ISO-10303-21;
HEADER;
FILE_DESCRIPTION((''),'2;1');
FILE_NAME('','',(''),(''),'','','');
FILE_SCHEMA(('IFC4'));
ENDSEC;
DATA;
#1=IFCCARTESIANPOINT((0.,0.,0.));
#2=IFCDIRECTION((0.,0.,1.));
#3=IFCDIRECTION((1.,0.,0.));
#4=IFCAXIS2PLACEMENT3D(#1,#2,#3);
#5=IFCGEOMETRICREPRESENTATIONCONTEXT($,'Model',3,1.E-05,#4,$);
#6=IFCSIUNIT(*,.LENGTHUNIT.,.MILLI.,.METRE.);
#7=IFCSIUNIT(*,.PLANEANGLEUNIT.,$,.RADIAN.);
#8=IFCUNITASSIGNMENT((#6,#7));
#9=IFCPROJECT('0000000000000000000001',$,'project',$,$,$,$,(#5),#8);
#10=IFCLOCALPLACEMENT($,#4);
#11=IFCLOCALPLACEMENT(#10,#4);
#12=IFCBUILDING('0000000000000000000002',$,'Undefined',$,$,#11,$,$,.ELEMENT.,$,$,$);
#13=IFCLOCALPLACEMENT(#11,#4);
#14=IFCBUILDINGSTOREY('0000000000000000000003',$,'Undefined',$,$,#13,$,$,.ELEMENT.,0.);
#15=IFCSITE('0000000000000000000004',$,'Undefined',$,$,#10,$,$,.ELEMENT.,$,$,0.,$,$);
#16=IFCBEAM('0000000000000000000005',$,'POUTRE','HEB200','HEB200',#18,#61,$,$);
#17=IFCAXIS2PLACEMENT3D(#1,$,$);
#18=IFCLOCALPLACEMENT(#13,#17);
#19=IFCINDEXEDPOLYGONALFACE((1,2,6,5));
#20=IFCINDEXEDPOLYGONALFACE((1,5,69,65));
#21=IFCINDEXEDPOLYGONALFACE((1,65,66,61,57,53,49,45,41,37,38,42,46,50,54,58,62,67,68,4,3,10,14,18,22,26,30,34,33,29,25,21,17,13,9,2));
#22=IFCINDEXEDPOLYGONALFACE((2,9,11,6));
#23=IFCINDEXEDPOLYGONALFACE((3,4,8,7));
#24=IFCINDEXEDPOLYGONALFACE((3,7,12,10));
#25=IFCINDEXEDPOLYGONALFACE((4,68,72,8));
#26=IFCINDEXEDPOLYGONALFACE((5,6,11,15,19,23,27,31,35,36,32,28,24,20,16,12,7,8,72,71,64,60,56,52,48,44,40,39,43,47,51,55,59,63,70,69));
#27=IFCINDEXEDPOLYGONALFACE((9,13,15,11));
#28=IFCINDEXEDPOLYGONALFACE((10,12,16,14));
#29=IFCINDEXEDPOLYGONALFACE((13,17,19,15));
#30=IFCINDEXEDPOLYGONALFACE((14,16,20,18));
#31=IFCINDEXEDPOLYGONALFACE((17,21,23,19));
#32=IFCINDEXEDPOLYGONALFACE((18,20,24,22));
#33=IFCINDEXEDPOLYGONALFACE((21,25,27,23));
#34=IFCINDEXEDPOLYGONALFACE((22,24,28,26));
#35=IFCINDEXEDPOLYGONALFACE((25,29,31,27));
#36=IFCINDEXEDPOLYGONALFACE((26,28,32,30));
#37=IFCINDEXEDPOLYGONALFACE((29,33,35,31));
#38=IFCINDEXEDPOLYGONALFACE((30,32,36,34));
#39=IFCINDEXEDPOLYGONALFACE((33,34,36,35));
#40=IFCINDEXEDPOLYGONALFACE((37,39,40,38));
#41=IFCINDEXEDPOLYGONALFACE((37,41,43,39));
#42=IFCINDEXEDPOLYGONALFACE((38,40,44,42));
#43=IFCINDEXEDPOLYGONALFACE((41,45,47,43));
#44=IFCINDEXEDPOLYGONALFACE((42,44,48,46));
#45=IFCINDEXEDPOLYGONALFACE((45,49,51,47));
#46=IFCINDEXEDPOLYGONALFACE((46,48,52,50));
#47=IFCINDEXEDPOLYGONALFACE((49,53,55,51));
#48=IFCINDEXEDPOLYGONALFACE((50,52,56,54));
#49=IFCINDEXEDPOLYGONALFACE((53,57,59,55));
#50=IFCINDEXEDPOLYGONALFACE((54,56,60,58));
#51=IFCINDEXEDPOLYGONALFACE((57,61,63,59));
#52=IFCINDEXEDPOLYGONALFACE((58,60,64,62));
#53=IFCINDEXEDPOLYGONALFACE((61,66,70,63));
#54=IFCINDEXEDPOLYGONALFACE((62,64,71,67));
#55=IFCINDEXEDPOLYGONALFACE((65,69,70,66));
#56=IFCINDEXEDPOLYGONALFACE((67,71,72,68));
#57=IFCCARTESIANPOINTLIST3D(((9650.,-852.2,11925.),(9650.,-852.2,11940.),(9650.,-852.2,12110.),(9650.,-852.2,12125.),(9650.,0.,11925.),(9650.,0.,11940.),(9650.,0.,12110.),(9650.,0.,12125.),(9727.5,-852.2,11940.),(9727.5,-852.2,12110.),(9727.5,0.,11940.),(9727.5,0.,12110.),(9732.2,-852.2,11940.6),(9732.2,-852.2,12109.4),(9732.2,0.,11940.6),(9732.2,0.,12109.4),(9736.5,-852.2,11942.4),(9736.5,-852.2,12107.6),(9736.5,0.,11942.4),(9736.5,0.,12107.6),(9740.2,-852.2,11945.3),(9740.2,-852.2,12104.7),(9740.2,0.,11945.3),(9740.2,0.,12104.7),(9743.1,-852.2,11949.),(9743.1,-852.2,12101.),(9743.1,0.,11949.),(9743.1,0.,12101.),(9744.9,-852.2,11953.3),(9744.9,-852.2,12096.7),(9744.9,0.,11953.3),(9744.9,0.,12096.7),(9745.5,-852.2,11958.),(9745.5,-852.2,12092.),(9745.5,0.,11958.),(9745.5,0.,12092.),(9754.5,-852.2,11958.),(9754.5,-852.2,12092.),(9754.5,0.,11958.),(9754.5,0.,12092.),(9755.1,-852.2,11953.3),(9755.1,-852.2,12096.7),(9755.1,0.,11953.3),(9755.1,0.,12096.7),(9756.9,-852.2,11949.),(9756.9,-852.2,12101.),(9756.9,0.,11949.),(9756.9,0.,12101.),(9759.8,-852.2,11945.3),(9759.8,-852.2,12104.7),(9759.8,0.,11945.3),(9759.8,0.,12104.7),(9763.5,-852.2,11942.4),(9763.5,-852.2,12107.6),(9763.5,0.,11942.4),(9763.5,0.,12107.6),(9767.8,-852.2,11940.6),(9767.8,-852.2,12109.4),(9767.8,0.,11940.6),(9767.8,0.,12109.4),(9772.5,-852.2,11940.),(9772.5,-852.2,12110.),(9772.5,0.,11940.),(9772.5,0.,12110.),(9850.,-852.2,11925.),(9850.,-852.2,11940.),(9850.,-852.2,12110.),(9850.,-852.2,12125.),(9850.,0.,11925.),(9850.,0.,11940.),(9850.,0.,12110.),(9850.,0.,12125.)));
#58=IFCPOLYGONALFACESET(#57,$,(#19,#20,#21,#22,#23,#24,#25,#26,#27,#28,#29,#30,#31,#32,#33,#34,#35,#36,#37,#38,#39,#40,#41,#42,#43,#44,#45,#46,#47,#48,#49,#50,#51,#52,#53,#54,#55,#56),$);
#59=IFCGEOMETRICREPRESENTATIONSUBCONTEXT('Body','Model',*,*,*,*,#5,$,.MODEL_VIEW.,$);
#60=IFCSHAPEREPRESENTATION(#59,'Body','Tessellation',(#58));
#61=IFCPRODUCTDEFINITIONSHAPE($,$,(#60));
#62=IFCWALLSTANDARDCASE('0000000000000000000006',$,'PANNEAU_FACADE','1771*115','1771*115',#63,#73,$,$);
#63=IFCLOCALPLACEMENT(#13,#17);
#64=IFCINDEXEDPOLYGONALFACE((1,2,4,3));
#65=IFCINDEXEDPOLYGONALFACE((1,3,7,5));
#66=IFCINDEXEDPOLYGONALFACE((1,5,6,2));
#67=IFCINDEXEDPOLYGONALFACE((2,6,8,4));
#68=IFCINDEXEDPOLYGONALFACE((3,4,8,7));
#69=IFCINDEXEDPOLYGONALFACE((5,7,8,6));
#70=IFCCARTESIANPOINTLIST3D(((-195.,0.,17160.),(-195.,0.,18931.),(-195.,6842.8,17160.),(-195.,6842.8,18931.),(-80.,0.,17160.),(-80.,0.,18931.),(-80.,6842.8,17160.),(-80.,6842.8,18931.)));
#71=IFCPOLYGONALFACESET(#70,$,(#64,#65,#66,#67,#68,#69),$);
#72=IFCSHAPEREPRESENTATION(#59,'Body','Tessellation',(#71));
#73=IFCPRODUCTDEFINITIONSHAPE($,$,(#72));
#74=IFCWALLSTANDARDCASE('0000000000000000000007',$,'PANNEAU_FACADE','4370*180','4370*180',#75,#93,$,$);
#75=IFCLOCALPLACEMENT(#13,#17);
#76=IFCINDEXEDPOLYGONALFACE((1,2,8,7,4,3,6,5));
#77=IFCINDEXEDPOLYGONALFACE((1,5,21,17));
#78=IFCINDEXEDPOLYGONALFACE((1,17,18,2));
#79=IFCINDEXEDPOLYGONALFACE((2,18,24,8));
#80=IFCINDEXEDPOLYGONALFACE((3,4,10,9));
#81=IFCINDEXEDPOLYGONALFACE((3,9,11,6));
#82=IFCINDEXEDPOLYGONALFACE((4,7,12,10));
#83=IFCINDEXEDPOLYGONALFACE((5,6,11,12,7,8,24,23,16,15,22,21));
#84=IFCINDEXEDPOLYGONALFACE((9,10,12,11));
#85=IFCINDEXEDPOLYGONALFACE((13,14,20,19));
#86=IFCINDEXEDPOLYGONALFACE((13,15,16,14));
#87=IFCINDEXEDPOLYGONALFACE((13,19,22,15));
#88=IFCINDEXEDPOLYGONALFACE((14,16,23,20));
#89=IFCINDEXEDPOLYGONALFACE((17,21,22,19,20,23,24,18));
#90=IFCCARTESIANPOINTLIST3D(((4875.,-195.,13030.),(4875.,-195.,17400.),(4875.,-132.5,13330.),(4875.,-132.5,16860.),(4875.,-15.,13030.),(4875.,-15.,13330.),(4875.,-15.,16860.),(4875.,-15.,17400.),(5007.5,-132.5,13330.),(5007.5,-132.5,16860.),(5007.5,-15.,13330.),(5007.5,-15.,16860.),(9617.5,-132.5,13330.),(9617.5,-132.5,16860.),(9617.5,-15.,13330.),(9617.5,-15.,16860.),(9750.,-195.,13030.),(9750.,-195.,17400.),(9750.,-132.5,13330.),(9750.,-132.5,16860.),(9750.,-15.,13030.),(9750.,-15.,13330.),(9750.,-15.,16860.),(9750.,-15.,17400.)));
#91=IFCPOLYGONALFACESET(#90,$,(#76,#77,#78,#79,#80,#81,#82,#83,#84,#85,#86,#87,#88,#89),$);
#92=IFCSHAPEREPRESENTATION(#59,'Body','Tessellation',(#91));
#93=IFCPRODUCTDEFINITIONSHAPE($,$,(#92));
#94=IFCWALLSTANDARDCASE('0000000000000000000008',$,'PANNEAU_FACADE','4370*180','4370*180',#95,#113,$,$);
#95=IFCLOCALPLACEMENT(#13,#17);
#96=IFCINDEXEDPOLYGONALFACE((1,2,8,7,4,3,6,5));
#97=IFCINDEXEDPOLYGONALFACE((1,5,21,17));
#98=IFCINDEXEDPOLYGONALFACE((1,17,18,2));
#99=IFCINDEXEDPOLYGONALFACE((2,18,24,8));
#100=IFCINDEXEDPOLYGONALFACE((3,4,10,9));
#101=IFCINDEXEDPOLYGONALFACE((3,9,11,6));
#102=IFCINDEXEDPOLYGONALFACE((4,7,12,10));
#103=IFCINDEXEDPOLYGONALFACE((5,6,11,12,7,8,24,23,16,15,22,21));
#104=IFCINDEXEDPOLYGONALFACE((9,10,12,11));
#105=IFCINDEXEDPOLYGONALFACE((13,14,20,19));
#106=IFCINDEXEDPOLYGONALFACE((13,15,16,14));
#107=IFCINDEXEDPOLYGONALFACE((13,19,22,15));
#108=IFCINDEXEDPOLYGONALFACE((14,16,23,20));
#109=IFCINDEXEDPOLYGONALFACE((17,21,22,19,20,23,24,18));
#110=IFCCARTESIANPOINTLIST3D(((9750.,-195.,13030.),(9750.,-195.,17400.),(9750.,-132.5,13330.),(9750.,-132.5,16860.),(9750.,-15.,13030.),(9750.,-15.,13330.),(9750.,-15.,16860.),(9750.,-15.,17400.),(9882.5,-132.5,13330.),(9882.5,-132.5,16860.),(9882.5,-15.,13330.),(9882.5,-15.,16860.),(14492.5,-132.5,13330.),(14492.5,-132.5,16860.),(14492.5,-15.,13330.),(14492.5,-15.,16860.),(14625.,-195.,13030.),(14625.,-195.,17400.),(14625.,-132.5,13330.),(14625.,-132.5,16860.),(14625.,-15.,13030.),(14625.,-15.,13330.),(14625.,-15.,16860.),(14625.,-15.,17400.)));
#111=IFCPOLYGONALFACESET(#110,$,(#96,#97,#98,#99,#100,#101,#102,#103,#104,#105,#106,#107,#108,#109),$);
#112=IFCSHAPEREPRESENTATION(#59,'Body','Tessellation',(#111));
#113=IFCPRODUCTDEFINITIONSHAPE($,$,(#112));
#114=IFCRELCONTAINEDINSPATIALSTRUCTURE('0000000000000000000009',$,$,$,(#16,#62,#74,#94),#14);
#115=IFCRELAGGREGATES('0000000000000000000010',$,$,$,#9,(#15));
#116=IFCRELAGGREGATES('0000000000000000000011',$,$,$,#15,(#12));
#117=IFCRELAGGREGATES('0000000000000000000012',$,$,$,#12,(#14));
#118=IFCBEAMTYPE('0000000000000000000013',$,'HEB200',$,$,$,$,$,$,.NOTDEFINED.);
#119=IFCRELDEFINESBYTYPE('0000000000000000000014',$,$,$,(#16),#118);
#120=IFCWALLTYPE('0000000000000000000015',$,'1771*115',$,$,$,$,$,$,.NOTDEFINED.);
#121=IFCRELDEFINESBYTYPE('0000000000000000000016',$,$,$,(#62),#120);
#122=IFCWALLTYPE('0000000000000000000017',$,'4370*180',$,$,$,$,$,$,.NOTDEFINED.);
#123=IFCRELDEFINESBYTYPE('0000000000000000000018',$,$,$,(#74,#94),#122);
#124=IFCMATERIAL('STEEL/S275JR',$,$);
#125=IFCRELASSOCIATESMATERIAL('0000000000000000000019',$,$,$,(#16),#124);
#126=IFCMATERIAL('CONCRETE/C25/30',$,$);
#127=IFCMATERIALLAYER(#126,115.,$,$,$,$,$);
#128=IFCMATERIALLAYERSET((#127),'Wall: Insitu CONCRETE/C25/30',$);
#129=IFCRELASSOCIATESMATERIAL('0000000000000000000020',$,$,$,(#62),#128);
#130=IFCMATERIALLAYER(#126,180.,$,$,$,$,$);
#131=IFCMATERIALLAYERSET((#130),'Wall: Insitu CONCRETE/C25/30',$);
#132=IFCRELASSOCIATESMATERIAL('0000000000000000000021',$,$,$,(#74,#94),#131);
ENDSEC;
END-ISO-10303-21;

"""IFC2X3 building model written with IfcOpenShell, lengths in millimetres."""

from ifc_helpers import new_model, si_unit, frame, frame_2d, origin_with_axes, origin_2d_with_axis, place, context, subcontext, project, spatial, rectangle, i_section, extrude, boolean, material, layer, layer_set, layer_usage, type_object, element, save


model = new_model("IFC2X3")

# Units and contexts
model_context = context("Model", 3, precision=1e-05, world=origin_with_axes())
body_context = subcontext(model_context, "Body", "Model", "MODEL_VIEW")
ifc_project = project(units=[si_unit("LENGTHUNIT", "METRE", prefix="MILLI"), si_unit("PLANEANGLEUNIT", "RADIAN")], contexts=[model_context])

# Site, building, storey
site_placement = place(None, origin_with_axes())
site = spatial("IfcSite", under=ifc_project, at=site_placement, Name="Undefined", CompositionType="ELEMENT", RefElevation=0.0)
building_placement = place(site_placement, origin_with_axes())
building = spatial("IfcBuilding", under=site, at=building_placement, Name="Undefined", CompositionType="ELEMENT")
storey_placement = place(building_placement, origin_with_axes())
storey = spatial("IfcBuildingStorey", under=building, at=storey_placement, Name="Undefined", CompositionType="ELEMENT", Elevation=0.0)

# Shared definitions
ifc_material_1 = material(Name="CONCRETE/C25/30")
ifc_material_2 = material(Name="STEEL/S275JR")

# Beam
beam_type_1 = type_object("IfcBeamType", Name="HEB200", PredefinedType="NOTDEFINED")
beam_1_placement = place(storey_placement, frame((9750.0, 0.0, 12025.0), z_axis=(0.0, 0.0, 1.0), x_axis=(0.0, -1.0, 0.0)))
element("IfcBeam", 1, at=beam_1_placement, inside=storey, type_object=beam_type_1, material=ifc_material_2, Name="POUTRE", Description="HEB200", ObjectType="HEB200", context=body_context, shape_type="SweptSolid", body=[
    extrude(i_section(OverallWidth=200.0, OverallDepth=200.0, WebThickness=9.0, FlangeThickness=15.0, FilletRadius=18.0, at=origin_2d_with_axis()), frame((852.2, 0.0, 0.0), z_axis=(-1.0, 0.0, 0.0), x_axis=(0.0, -1.0, 0.0)), (0.0, 0.0, 1.0), 852.2),
])

# Walls
ifc_layer_1 = layer(ifc_material_1, 115.0)
ifc_layer_set_1 = layer_set([ifc_layer_1], Name="Wall: Insitu CONCRETE/C25/30")
ifc_layer_usage_1 = layer_usage(ifc_layer_set_1, "AXIS2", "POSITIVE", -57.5)
wall_type_1 = type_object("IfcWallType", Name="1771*115", PredefinedType="NOTDEFINED")
wall_1_placement = place(storey_placement, frame((-137.5, 0.0, 17160.0), z_axis=(0.0, 0.0, 1.0), x_axis=(0.0, 1.0, 0.0)))
element("IfcWallStandardCase", 2, at=wall_1_placement, inside=storey, type_object=wall_type_1, material=ifc_layer_usage_1, Name="PANNEAU_FACADE", Description="1771*115", ObjectType="1771*115", context=body_context, shape_type="SweptSolid", body=[
    extrude(rectangle(XDim=6842.8, YDim=115.0, at=frame_2d((0.0, 3421.4), x_axis=(0.0, -1.0))), frame((0.0, 0.0, 0.0), z_axis=(0.0, 0.0, 1.0), x_axis=(0.0, -1.0, 0.0)), (0.0, 0.0, 1.0), 1771.0),
])
ifc_layer_2 = layer(ifc_material_1, 180.0)
ifc_layer_set_2 = layer_set([ifc_layer_2], Name="Wall: Insitu CONCRETE/C25/30")
ifc_layer_usage_2 = layer_usage(ifc_layer_set_2, "AXIS2", "POSITIVE", -90.0)
wall_type_2 = type_object("IfcWallType", Name="4370*180", PredefinedType="NOTDEFINED")
wall_2_placement = place(storey_placement, frame((9750.0, -105.0, 13030.0), z_axis=(0.0, 0.0, 1.0), x_axis=(-1.0, 0.0, 0.0)))
element("IfcWallStandardCase", 3, at=wall_2_placement, inside=storey, type_object=wall_type_2, material=ifc_layer_usage_2, Name="PANNEAU_FACADE", Description="4370*180", ObjectType="4370*180", context=body_context, shape_type="CSG", body=[
    boolean("DIFFERENCE", boolean("DIFFERENCE", extrude(rectangle(XDim=4875.0, YDim=180.0, at=frame_2d((0.0, 2437.5), x_axis=(0.0, -1.0))), frame((0.0, 0.0, 0.0), z_axis=(0.0, 0.0, 1.0), x_axis=(0.0, -1.0, 0.0)), (0.0, 0.0, 1.0), 4370.0), extrude(rectangle(XDim=265.0, YDim=265.0, at=origin_2d_with_axis()), frame((0.0, -105.0, 3830.0), z_axis=(0.0, 0.0, -1.0), x_axis=(1.0, 0.0, 0.0)), (0.0, 0.0, 1.0), 3530.0)), extrude(rectangle(XDim=265.0, YDim=265.0, at=origin_2d_with_axis()), frame((4875.0, -105.0, 3830.0), z_axis=(0.0, 0.0, -1.0), x_axis=(1.0, 0.0, 0.0)), (0.0, 0.0, 1.0), 3530.0)),
])
ifc_layer_usage_3 = layer_usage(ifc_layer_set_2, "AXIS2", "POSITIVE", -90.0)
wall_3_placement = place(storey_placement, frame((14625.0, -105.0, 13030.0), z_axis=(0.0, 0.0, 1.0), x_axis=(-1.0, 0.0, 0.0)))
element("IfcWallStandardCase", 4, at=wall_3_placement, inside=storey, type_object=wall_type_2, material=ifc_layer_usage_3, Name="PANNEAU_FACADE", Description="4370*180", ObjectType="4370*180", context=body_context, shape_type="CSG", body=[
    boolean("DIFFERENCE", boolean("DIFFERENCE", extrude(rectangle(XDim=4875.0, YDim=180.0, at=frame_2d((0.0, 2437.5), x_axis=(0.0, -1.0))), frame((0.0, 0.0, 0.0), z_axis=(0.0, 0.0, 1.0), x_axis=(0.0, -1.0, 0.0)), (0.0, 0.0, 1.0), 4370.0), extrude(rectangle(XDim=265.0, YDim=265.0, at=origin_2d_with_axis()), frame((0.0, -105.0, 3830.0), z_axis=(0.0, 0.0, -1.0), x_axis=(1.0, 0.0, 0.0)), (0.0, 0.0, 1.0), 3530.0)), extrude(rectangle(XDim=265.0, YDim=265.0, at=origin_2d_with_axis()), frame((4875.0, -105.0, 3830.0), z_axis=(0.0, 0.0, -1.0), x_axis=(1.0, 0.0, 0.0)), (0.0, 0.0, 1.0), 3530.0)),
])

save(model, "model.ifc")
